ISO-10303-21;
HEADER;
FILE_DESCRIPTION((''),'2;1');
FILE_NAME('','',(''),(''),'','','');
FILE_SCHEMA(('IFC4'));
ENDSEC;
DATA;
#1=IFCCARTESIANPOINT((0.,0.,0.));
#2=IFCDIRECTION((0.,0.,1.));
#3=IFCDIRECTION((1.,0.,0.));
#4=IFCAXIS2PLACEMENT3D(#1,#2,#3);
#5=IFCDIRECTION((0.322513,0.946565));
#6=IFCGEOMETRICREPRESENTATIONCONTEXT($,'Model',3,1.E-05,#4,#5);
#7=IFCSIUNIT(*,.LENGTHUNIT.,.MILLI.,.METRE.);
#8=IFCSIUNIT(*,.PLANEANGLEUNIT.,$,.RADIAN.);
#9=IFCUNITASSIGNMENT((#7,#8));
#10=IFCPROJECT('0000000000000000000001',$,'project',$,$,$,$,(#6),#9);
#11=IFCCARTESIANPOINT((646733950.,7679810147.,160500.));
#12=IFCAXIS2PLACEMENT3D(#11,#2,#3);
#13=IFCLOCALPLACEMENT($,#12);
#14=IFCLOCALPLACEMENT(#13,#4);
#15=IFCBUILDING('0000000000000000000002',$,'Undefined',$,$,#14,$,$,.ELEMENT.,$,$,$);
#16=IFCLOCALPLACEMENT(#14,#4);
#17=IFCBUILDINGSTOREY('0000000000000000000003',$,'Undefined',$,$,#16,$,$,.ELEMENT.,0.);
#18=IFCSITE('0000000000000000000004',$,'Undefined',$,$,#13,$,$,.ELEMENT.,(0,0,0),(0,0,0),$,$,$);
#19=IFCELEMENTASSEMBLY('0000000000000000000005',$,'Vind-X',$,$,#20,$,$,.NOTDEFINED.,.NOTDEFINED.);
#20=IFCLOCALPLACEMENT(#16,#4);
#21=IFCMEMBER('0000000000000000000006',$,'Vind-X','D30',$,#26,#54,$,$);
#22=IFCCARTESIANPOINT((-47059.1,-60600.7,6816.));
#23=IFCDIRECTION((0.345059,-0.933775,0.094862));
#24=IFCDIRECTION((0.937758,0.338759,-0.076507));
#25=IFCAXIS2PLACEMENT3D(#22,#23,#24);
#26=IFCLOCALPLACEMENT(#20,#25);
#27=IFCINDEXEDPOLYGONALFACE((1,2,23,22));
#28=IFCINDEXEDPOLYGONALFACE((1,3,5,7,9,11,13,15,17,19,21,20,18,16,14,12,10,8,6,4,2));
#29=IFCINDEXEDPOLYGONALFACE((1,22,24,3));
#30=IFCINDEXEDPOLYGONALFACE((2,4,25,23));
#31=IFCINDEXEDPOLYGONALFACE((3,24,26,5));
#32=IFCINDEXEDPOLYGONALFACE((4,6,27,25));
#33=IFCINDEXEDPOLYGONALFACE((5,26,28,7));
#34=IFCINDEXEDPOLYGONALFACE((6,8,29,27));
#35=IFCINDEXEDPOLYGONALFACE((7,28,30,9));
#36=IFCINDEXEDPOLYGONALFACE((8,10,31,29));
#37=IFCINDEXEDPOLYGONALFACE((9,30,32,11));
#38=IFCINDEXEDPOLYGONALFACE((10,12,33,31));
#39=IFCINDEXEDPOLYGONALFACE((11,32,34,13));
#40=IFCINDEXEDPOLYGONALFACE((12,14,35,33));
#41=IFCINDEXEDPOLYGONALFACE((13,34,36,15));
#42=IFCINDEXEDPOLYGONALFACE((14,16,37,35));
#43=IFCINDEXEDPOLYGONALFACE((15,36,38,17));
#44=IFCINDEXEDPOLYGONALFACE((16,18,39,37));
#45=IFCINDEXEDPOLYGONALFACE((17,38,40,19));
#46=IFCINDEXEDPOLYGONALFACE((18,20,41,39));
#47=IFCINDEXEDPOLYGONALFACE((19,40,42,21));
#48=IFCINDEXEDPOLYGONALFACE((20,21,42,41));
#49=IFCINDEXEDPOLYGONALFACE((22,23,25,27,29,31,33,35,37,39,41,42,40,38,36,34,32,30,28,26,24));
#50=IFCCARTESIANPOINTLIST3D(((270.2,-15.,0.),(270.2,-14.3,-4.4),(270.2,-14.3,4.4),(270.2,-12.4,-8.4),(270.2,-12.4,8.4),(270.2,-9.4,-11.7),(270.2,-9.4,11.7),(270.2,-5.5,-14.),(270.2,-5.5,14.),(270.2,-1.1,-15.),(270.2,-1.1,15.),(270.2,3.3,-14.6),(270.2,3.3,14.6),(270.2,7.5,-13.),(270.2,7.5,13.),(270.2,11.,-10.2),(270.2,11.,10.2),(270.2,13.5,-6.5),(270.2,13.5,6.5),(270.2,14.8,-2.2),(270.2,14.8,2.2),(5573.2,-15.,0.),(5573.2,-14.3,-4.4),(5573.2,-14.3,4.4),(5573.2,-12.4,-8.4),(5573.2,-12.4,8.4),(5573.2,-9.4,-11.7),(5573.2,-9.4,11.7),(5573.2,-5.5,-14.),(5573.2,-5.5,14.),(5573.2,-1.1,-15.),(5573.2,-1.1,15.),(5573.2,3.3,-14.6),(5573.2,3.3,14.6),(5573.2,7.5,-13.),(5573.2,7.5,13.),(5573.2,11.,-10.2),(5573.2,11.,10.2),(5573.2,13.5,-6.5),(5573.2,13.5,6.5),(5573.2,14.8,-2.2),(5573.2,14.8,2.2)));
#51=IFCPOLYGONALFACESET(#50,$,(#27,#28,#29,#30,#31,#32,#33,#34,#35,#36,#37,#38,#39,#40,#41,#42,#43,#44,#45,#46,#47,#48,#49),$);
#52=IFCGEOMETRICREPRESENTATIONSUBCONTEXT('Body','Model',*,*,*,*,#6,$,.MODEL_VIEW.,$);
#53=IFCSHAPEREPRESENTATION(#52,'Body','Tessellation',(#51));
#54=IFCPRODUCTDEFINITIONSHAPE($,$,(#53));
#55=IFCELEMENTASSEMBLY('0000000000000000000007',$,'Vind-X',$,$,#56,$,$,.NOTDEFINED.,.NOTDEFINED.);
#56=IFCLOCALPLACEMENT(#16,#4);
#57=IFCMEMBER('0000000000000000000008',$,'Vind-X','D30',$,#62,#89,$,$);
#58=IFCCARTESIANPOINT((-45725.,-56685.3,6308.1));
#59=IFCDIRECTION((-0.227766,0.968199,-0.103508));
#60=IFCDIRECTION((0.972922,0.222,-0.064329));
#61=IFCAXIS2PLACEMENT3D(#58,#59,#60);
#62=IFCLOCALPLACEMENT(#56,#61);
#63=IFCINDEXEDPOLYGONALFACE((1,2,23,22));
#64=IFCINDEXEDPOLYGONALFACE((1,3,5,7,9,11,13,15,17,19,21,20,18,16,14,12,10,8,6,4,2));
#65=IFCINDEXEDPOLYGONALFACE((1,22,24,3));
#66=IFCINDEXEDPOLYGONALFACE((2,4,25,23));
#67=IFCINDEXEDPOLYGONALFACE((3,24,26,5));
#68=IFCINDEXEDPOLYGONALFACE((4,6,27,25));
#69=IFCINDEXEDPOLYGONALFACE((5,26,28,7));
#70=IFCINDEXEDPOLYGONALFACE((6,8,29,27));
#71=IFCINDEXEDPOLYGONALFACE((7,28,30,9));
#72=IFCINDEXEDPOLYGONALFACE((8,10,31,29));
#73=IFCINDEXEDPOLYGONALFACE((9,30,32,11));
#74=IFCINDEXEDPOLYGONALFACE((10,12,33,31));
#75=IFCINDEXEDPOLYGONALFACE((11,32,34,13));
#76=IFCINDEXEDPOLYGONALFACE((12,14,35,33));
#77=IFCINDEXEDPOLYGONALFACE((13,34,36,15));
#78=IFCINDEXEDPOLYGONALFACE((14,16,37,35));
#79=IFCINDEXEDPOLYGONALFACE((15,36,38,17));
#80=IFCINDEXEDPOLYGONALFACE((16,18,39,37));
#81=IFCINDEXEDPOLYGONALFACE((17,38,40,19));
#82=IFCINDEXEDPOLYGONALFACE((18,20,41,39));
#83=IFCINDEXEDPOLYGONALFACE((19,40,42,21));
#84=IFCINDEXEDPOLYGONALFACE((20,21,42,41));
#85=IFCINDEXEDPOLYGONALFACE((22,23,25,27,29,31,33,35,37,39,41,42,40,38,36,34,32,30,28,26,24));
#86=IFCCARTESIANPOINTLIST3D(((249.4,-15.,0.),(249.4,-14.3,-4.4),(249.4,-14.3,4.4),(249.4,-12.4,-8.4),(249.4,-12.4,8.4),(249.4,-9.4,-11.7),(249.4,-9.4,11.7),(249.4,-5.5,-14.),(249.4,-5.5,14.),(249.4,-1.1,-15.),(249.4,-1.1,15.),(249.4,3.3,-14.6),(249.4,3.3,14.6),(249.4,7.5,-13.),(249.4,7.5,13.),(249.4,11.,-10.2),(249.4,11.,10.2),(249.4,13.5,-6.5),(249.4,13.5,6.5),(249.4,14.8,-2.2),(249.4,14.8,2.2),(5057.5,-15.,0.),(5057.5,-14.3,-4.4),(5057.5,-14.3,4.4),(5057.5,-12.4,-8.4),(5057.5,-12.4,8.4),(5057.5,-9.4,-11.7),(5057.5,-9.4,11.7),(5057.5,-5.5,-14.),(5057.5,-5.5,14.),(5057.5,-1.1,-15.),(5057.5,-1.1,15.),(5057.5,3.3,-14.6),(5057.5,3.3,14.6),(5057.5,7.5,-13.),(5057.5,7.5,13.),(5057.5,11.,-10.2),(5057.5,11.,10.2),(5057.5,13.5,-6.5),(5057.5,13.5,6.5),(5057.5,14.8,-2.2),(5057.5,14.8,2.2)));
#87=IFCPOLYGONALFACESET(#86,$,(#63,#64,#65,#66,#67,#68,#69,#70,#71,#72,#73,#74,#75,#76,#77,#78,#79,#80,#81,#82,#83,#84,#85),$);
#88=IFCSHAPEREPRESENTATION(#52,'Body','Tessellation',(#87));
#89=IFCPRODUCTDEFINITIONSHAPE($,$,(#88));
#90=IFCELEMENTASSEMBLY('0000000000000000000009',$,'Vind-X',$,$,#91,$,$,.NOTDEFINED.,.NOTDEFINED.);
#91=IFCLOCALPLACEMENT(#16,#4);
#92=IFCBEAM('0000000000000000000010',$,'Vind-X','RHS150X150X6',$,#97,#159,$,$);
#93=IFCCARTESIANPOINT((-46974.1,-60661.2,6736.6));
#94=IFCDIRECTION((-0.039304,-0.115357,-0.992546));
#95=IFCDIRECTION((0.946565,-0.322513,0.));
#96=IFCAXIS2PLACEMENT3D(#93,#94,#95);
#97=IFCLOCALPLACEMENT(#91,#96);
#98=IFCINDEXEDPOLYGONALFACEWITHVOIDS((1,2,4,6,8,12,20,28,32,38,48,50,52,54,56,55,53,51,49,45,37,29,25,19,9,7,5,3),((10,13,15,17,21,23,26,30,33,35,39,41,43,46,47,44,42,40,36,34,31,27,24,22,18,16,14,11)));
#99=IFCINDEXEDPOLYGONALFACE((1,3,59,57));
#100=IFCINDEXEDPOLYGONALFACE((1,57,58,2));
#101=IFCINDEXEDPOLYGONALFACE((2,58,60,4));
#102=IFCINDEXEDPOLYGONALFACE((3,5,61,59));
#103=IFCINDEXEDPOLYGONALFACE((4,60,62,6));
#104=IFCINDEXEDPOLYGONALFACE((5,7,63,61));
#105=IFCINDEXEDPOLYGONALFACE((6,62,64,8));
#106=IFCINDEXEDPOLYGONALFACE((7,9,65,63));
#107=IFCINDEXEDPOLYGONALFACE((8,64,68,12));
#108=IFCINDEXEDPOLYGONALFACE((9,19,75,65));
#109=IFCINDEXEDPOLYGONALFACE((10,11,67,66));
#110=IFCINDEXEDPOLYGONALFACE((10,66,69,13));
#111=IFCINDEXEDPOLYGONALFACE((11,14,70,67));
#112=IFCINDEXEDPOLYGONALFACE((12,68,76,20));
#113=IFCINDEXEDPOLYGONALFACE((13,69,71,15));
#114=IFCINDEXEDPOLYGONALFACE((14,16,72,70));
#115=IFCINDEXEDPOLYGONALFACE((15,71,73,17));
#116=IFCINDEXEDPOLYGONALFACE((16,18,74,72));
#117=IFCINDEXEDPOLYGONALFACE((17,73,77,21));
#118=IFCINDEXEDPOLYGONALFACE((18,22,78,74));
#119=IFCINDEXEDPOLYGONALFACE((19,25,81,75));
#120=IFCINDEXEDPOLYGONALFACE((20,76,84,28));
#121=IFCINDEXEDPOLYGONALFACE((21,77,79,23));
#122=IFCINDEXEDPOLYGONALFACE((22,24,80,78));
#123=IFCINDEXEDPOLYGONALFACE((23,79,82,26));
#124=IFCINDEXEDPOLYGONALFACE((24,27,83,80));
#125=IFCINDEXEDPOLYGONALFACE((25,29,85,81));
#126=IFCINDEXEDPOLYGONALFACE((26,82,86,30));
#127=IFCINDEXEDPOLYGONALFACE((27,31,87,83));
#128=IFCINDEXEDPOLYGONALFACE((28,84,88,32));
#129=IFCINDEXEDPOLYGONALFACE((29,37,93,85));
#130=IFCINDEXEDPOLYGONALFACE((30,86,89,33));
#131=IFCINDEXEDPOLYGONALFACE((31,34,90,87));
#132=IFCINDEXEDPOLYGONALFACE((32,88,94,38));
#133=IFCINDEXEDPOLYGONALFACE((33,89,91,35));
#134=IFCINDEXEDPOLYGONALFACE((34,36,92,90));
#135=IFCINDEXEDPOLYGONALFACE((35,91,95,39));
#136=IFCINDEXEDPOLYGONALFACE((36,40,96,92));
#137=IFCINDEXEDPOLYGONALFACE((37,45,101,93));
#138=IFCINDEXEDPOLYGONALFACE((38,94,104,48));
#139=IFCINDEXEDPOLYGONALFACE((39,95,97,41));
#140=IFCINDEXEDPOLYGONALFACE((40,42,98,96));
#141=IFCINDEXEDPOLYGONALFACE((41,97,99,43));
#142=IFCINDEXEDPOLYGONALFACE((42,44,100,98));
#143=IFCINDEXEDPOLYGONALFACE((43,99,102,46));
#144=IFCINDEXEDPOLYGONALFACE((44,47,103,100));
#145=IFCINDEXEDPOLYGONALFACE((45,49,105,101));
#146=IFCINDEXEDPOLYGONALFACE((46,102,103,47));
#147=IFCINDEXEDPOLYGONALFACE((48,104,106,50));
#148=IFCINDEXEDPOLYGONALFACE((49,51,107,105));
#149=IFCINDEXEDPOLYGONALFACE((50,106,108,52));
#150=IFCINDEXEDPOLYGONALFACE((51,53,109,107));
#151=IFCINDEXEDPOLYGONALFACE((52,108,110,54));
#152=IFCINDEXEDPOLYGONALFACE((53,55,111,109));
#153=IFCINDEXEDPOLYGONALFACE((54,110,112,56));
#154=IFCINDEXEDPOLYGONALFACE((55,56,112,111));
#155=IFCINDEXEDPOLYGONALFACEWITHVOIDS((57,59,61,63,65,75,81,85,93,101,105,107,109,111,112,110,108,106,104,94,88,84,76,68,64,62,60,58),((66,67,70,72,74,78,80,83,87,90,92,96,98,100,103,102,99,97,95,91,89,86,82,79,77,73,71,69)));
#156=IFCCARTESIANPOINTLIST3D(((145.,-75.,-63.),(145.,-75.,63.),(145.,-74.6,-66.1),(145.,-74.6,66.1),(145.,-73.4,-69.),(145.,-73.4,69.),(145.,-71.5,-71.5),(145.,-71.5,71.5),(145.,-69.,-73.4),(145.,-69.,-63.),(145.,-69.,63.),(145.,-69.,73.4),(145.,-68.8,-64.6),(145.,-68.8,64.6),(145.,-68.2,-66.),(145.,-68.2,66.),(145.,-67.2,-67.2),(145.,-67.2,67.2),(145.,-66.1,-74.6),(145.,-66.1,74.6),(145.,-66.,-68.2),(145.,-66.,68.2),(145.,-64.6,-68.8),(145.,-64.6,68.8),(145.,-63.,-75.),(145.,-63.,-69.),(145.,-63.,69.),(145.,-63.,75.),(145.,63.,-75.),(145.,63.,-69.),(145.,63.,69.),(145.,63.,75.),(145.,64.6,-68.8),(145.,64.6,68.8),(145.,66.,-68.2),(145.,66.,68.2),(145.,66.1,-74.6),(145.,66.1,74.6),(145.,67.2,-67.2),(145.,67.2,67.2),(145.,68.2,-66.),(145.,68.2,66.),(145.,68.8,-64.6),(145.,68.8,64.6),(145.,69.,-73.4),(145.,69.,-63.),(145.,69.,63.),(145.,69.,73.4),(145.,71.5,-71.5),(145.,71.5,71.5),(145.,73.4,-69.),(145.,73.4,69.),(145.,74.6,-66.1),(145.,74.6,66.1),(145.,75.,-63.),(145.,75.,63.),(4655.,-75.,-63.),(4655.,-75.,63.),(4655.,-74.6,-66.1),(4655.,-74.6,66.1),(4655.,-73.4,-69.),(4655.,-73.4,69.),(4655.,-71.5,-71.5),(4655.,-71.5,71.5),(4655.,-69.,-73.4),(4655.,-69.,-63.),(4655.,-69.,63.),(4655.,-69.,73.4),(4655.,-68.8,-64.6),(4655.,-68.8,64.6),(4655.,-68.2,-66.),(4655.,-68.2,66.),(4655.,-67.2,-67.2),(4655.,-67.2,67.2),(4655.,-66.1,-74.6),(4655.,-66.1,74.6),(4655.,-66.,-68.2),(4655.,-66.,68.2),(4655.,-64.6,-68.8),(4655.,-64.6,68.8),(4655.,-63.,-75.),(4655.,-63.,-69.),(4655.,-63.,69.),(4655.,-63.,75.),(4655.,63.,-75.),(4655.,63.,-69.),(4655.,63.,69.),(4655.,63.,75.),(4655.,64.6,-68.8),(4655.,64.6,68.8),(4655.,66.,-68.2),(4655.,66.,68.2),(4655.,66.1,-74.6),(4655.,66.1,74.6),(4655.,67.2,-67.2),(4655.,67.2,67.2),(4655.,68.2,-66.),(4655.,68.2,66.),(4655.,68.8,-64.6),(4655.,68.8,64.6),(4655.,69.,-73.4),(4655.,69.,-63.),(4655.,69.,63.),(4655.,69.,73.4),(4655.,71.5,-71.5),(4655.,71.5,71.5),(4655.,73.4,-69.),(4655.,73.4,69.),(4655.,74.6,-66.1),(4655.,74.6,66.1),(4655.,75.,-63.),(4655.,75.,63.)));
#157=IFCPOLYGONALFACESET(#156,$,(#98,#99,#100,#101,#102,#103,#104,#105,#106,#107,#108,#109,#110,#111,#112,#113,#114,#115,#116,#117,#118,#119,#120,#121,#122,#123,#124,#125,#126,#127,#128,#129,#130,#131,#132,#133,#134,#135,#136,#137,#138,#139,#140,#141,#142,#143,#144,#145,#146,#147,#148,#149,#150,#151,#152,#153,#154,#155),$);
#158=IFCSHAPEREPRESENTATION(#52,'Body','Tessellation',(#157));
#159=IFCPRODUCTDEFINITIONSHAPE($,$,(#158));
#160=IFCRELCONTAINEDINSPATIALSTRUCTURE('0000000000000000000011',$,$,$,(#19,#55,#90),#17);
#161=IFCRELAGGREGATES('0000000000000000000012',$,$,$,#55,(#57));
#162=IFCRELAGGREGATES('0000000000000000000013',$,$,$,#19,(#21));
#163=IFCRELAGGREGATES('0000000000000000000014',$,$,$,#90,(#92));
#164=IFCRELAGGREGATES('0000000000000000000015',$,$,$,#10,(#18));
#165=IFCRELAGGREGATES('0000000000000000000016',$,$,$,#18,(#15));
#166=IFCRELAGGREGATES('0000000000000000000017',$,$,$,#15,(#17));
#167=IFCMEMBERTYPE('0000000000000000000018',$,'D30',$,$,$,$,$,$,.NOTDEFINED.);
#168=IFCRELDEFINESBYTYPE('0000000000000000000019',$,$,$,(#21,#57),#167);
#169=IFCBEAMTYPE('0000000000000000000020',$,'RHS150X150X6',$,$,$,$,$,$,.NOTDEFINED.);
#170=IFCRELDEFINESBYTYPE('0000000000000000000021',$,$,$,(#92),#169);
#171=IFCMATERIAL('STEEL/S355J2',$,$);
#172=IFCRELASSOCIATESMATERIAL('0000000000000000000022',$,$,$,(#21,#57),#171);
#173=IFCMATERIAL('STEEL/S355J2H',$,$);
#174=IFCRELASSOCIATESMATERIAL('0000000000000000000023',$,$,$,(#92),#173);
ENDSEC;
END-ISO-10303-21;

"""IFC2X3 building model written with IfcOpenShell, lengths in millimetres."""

from ifc_helpers import new_model, si_unit, direction, frame, origin_with_axes, origin_2d_with_axis, place, context, subcontext, project, spatial, hollow_rectangle, circle, extrude, clip, halfspace, material, type_object, element, aggregate, save


model = new_model("IFC2X3")

# Units and contexts
model_context = context("Model", 3, precision=1e-05, world=origin_with_axes(), true_north=direction((0.322513, 0.946565)))
body_context = subcontext(model_context, "Body", "Model", "MODEL_VIEW")
ifc_project = project(units=[si_unit("LENGTHUNIT", "METRE", prefix="MILLI"), si_unit("PLANEANGLEUNIT", "RADIAN")], contexts=[model_context])

# Site, building, storey
site_placement = place(None, frame((646733950.0, 7679810147.0, 160500.0), z_axis=(0.0, 0.0, 1.0), x_axis=(1.0, 0.0, 0.0)))
site = spatial("IfcSite", under=ifc_project, at=site_placement, Name="Undefined", CompositionType="ELEMENT", RefLatitude=(0, 0, 0), RefLongitude=(0, 0, 0))
building_placement = place(site_placement, origin_with_axes())
building = spatial("IfcBuilding", under=site, at=building_placement, Name="Undefined", CompositionType="ELEMENT")
storey_placement = place(building_placement, origin_with_axes())
storey = spatial("IfcBuildingStorey", under=building, at=storey_placement, Name="Undefined", CompositionType="ELEMENT", Elevation=0.0)

# Element assemblies, members
assembly_1_placement = place(storey_placement, origin_with_axes())
assembly_1 = element("IfcElementAssembly", 1, at=assembly_1_placement, inside=storey, Name="Vind-X", AssemblyPlace="NOTDEFINED", PredefinedType="NOTDEFINED")
ifc_material_1 = material(Name="STEEL/S355J2")
member_type_1 = type_object("IfcMemberType", Name="D30", PredefinedType="NOTDEFINED")
member_1_placement = place(assembly_1_placement, frame((-47059.1, -60600.7, 6816.0), z_axis=(0.345059, -0.933775, 0.094862), x_axis=(0.937758, 0.338759, -0.076507)))
member_1 = element("IfcMember", 2, at=member_1_placement, type_object=member_type_1, material=ifc_material_1, Name="Vind-X", Description="D30", context=body_context, shape_type="Clipping", body=[
    clip(extrude(circle(Radius=15.0, at=origin_2d_with_axis()), frame((5573.2, 0.0, 0.0), z_axis=(-1.0, 0.0, 0.0), x_axis=(0.0, -1.0, 0.0)), (0.0, 0.0, 1.0), 5573.2), halfspace(frame((270.2, -22.5, 0.0), z_axis=(1.0, 0.0, 0.0), x_axis=(0.0, 0.0, 1.0)), True)),
])
assembly_2_placement = place(storey_placement, origin_with_axes())
assembly_2 = element("IfcElementAssembly", 3, at=assembly_2_placement, inside=storey, Name="Vind-X", AssemblyPlace="NOTDEFINED", PredefinedType="NOTDEFINED")
member_2_placement = place(assembly_2_placement, frame((-45725.0, -56685.3, 6308.1), z_axis=(-0.227766, 0.968199, -0.103508), x_axis=(0.972922, 0.222, -0.064329)))
member_2 = element("IfcMember", 4, at=member_2_placement, type_object=member_type_1, material=ifc_material_1, Name="Vind-X", Description="D30", context=body_context, shape_type="Clipping", body=[
    clip(extrude(circle(Radius=15.0, at=origin_2d_with_axis()), frame((5057.5, 0.0, 0.0), z_axis=(-1.0, 0.0, 0.0), x_axis=(0.0, -1.0, 0.0)), (0.0, 0.0, 1.0), 5057.5), halfspace(frame((249.4, 22.5, 0.0), z_axis=(1.0, 0.0, 0.0), x_axis=(0.0, 0.0, -1.0)), True)),
])

# Element assembly, beam
assembly_3_placement = place(storey_placement, origin_with_axes())
assembly_3 = element("IfcElementAssembly", 5, at=assembly_3_placement, inside=storey, Name="Vind-X", AssemblyPlace="NOTDEFINED", PredefinedType="NOTDEFINED")
ifc_material_2 = material(Name="STEEL/S355J2H")
beam_type_1 = type_object("IfcBeamType", Name="RHS150X150X6", PredefinedType="NOTDEFINED")
beam_1_placement = place(assembly_3_placement, frame((-46974.1, -60661.2, 6736.6), z_axis=(-0.039304, -0.115357, -0.992546), x_axis=(0.946565, -0.322513, 0.0)))
beam_1 = element("IfcBeam", 6, at=beam_1_placement, type_object=beam_type_1, material=ifc_material_2, Name="Vind-X", Description="RHS150X150X6", context=body_context, shape_type="Clipping", body=[
    clip(clip(extrude(hollow_rectangle(XDim=150.0, YDim=150.0, WallThickness=6.0, InnerFilletRadius=6.0, OuterFilletRadius=12.0, at=origin_2d_with_axis()), frame((4800.0, 0.0, 0.0), z_axis=(-1.0, 0.0, 0.0), x_axis=(0.0, -1.0, 0.0)), (0.0, 0.0, 1.0), 4800.0), halfspace(frame((4655.0, 0.0, 0.0), z_axis=(-1.0, 0.0, 0.0), x_axis=(0.0, 1.0, 0.0)), True)), halfspace(frame((145.0, 0.0, 0.0), z_axis=(1.0, 0.0, 0.0), x_axis=(0.0, -1.0, 0.0)), True)),
])

aggregate(assembly_2, [member_2])
aggregate(assembly_1, [member_1])
aggregate(assembly_3, [beam_1])

save(model, "model.ifc")
